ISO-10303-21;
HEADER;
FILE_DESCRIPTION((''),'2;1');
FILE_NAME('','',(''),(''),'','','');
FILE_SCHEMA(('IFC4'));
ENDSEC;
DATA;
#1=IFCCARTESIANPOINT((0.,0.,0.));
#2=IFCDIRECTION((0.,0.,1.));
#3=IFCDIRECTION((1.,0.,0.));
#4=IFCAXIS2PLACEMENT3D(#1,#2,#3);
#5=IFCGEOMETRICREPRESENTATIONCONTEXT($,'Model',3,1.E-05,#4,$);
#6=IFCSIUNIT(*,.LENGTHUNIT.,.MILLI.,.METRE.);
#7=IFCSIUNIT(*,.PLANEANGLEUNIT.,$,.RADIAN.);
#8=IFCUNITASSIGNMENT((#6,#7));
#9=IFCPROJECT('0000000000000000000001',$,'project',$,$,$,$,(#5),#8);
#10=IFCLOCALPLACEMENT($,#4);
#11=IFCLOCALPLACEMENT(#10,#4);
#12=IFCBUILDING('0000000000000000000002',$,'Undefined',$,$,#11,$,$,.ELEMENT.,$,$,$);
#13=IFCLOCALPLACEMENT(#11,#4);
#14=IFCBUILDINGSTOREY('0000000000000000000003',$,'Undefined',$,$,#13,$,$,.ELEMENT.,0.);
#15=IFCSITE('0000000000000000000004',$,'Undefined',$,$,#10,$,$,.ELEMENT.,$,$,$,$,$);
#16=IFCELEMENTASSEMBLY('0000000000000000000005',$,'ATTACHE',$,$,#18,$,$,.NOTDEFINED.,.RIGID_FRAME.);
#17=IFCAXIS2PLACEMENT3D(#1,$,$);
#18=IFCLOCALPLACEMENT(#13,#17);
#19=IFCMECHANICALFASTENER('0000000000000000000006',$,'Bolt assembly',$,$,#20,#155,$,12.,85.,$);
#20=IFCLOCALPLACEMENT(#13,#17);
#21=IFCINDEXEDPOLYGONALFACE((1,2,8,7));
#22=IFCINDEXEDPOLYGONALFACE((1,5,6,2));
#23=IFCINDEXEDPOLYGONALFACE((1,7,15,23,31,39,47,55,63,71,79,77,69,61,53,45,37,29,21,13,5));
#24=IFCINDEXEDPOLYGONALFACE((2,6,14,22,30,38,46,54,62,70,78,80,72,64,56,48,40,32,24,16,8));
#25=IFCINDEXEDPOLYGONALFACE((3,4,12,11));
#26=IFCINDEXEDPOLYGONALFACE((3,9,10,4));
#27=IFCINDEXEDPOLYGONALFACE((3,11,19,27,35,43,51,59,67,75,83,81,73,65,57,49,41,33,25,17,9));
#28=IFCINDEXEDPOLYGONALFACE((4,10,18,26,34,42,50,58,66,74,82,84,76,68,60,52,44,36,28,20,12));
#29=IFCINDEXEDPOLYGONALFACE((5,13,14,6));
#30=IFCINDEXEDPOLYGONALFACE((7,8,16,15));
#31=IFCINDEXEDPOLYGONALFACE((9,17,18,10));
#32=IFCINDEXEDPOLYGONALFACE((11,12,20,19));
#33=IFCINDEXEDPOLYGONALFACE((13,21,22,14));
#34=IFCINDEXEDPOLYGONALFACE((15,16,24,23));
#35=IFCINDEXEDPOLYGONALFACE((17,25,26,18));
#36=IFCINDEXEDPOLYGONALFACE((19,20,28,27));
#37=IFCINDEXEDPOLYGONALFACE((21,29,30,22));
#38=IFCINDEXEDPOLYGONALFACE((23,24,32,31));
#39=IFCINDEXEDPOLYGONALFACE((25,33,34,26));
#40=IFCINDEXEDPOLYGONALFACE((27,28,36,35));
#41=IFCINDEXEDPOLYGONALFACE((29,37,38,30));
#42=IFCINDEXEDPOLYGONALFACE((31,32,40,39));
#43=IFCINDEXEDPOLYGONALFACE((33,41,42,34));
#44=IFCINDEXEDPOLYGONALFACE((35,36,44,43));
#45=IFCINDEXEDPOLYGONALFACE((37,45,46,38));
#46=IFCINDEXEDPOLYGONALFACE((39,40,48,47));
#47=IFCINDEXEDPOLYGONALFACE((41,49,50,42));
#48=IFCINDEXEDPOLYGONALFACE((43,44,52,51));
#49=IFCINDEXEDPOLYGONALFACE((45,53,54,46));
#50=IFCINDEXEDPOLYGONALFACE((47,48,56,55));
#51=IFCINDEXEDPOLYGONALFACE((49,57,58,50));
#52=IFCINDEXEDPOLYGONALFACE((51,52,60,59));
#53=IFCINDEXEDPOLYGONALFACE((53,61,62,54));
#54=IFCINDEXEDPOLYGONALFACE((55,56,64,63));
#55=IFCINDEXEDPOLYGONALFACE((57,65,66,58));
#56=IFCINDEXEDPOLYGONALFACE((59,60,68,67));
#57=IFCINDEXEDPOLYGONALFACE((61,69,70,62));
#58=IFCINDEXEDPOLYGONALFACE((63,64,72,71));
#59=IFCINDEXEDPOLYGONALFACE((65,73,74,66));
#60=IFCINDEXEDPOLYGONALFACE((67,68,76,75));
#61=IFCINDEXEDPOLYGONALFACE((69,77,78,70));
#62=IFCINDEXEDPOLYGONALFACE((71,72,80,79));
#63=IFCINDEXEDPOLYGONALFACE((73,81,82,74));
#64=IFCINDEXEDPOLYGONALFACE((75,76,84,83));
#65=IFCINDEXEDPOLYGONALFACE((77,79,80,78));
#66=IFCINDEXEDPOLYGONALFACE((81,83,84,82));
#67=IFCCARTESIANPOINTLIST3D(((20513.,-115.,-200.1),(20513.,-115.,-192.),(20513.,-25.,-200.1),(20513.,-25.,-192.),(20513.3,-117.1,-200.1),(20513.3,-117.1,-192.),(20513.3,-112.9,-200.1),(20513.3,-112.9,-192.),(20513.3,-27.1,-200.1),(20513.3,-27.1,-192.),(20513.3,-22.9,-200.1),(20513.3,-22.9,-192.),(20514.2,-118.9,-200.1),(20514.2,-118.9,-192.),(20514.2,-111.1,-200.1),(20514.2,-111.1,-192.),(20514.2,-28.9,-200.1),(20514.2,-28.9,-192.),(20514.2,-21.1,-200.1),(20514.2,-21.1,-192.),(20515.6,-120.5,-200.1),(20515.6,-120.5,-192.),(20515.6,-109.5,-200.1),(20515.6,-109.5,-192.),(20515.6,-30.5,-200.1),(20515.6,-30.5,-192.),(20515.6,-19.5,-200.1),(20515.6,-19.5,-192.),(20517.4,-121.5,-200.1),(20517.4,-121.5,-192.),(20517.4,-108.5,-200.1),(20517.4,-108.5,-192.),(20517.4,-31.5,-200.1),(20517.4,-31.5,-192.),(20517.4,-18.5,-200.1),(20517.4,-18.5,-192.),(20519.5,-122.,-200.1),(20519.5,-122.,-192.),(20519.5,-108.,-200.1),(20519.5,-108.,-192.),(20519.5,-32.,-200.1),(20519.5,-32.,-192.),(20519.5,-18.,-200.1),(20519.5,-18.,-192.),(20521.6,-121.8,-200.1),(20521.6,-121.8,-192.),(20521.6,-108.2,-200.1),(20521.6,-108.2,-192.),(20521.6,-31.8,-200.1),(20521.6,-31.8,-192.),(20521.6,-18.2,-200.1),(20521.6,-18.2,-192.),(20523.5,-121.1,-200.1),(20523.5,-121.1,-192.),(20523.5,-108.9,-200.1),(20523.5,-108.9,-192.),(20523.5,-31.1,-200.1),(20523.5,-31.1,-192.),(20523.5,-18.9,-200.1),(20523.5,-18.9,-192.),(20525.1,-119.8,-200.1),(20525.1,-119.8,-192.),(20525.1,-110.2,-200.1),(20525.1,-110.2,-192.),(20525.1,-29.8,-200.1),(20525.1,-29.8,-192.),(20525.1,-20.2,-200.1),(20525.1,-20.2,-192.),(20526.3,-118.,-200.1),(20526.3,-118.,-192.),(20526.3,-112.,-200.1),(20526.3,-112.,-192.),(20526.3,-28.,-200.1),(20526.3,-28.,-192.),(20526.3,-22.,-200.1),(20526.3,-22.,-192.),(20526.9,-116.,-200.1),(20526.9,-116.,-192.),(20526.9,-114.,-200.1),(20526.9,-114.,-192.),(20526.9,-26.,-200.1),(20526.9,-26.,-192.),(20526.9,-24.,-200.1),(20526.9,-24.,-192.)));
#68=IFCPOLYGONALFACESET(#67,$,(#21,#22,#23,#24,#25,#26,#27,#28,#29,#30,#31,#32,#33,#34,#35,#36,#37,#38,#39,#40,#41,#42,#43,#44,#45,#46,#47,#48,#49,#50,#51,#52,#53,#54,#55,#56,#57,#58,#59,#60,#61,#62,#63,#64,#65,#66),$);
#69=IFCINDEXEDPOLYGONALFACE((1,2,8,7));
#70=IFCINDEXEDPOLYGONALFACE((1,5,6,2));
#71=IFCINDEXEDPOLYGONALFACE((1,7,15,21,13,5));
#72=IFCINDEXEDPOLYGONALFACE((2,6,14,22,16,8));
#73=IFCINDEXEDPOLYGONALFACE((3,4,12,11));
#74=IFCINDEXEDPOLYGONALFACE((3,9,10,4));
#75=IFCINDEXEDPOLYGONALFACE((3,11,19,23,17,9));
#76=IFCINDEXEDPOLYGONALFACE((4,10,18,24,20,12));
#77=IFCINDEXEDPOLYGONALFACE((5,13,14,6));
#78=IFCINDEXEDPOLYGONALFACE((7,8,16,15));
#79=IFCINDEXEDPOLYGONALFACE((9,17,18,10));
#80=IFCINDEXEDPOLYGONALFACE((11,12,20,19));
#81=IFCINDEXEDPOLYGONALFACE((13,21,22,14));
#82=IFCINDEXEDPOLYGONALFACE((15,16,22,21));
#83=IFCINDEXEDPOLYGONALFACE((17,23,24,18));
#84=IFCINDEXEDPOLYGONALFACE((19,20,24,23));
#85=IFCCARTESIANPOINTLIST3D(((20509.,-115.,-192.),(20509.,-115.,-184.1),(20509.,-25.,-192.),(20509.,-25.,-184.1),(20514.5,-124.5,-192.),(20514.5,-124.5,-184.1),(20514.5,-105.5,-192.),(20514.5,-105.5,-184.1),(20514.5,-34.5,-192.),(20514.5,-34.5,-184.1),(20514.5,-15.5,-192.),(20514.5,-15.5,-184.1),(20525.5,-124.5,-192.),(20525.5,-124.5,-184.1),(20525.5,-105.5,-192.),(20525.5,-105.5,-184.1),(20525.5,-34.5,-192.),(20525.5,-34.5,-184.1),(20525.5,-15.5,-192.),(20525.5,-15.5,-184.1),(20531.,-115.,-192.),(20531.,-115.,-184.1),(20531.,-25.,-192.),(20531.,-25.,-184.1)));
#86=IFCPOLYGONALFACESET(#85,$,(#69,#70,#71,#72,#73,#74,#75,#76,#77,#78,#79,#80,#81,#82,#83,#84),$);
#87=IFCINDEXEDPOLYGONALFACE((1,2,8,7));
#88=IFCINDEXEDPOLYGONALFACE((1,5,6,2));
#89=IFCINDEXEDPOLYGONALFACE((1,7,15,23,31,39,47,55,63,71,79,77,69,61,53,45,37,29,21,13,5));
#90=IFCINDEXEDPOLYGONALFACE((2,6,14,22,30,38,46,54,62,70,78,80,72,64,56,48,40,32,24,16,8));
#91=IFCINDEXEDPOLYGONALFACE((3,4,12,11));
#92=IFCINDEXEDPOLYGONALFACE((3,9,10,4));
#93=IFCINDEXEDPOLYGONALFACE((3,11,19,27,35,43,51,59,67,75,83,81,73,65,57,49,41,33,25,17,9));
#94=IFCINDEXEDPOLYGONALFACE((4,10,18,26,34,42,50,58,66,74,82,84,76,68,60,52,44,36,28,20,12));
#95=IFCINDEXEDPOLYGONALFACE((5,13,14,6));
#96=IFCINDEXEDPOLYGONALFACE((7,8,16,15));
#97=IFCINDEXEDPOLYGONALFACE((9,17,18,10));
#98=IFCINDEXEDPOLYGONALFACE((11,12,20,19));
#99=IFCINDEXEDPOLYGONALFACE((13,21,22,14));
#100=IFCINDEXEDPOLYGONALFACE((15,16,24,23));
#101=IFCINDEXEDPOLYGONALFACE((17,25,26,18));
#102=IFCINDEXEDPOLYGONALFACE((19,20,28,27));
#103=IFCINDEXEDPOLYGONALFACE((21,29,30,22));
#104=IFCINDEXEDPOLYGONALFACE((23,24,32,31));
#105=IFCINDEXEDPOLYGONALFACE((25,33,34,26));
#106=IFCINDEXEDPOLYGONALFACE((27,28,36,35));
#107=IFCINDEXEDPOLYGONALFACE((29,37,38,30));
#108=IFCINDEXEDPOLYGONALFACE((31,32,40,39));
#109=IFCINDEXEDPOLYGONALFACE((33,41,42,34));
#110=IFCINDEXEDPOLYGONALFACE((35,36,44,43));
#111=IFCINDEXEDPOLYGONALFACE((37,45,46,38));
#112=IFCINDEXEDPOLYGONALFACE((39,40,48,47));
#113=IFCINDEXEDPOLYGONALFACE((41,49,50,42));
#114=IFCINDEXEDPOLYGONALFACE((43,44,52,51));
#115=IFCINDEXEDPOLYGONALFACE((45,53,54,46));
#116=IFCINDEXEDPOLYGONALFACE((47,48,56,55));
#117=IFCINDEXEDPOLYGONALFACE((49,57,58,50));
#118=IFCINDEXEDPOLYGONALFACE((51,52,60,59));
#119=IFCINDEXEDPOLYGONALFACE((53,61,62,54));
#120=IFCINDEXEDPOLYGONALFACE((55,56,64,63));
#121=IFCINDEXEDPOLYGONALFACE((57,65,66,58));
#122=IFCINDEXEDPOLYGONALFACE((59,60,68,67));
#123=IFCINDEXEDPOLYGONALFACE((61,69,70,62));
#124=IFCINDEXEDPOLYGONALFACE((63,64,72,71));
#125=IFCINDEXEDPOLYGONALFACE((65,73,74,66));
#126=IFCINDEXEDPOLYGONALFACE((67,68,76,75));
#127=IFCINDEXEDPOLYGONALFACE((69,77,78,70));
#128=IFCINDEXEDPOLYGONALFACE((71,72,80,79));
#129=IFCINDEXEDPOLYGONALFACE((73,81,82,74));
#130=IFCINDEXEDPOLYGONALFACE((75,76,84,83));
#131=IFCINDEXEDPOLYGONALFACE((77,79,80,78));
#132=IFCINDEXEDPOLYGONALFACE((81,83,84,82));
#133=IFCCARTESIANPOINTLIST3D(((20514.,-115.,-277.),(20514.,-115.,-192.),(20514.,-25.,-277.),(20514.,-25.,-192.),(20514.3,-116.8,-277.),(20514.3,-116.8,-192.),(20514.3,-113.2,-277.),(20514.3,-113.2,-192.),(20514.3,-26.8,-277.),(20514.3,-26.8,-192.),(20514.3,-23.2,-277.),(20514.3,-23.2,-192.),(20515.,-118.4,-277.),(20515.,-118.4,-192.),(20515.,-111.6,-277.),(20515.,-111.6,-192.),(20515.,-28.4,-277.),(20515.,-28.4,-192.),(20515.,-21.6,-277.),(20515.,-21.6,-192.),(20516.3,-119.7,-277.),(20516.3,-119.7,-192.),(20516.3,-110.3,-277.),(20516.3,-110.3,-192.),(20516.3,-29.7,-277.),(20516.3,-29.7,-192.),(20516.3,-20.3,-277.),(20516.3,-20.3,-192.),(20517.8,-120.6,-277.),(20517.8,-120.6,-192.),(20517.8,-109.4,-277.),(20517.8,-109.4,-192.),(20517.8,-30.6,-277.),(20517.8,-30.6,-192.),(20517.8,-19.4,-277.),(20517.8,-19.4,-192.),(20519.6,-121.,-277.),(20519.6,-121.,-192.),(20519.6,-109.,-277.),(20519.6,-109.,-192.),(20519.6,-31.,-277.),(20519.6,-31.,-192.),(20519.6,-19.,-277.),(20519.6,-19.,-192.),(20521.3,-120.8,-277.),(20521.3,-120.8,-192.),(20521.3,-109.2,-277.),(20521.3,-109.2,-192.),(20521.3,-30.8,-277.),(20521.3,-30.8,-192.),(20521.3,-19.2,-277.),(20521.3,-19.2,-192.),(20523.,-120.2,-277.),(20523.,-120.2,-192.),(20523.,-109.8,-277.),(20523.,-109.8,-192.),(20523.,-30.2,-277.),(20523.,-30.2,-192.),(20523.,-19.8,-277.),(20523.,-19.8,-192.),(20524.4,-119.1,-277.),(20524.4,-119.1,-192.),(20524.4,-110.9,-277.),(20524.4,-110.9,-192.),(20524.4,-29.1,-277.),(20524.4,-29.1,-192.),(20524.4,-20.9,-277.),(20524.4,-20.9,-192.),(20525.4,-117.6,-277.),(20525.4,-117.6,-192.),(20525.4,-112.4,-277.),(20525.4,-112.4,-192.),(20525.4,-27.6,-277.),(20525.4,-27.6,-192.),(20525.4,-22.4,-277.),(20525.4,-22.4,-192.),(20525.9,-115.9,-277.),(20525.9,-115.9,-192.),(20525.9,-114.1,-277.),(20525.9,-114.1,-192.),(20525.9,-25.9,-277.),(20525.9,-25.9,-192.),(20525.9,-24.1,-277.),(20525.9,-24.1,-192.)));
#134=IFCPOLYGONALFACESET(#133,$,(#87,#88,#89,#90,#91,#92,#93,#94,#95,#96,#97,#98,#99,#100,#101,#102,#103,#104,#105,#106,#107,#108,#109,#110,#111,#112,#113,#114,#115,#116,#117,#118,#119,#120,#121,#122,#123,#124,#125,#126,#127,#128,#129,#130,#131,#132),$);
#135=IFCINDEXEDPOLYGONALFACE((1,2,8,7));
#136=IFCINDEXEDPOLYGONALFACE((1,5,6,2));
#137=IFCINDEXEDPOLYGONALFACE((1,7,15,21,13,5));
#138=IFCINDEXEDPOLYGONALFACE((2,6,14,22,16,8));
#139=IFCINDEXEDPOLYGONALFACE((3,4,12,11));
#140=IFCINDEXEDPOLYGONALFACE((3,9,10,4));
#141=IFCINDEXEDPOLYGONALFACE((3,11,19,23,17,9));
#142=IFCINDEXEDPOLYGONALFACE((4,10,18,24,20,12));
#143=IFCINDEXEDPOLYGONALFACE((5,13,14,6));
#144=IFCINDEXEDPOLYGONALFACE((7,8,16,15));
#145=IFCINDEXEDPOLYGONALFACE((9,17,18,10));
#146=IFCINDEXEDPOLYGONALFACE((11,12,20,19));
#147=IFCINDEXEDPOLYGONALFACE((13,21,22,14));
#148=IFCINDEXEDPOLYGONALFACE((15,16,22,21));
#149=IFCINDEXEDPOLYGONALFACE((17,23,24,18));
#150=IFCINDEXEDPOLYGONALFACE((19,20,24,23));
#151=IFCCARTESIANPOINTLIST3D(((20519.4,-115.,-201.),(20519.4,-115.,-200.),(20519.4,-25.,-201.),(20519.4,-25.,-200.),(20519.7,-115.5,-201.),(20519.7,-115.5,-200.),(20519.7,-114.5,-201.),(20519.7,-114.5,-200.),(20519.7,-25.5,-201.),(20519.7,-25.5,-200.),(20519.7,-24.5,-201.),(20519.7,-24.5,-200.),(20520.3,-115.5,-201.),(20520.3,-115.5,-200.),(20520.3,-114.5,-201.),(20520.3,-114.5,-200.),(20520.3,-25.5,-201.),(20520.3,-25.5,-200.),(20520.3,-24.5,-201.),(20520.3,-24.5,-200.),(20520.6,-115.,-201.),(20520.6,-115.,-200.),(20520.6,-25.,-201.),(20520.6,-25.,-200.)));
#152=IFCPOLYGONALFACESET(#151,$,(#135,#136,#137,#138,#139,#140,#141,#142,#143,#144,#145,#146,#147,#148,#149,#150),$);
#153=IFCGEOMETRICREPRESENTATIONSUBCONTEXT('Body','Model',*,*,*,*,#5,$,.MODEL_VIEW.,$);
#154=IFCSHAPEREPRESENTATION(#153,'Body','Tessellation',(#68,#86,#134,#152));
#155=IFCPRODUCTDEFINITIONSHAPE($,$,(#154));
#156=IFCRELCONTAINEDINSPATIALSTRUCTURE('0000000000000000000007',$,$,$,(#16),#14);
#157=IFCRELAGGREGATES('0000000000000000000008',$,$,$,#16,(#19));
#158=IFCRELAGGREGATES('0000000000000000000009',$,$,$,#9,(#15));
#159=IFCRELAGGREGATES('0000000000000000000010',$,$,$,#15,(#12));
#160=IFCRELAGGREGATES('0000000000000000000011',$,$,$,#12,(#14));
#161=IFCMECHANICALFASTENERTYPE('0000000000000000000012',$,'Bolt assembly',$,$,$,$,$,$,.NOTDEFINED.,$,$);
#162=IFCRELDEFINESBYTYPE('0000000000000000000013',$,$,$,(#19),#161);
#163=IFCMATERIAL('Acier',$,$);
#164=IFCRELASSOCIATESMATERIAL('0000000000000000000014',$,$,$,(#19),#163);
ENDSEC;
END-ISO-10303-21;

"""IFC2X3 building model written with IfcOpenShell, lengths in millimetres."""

from ifc_helpers import new_model, si_unit, frame, origin_with_axes, origin_2d_with_axis, place, context, subcontext, project, spatial, polyline, circle, outline, extrude, source, transform, mapped, material, type_object, element, aggregate, save


model = new_model("IFC2X3")

# Units and contexts
model_context = context("Model", 3, precision=1e-05, world=origin_with_axes())
body_context = subcontext(model_context, "Body", "Model", "MODEL_VIEW")
ifc_project = project(units=[si_unit("LENGTHUNIT", "METRE", prefix="MILLI"), si_unit("PLANEANGLEUNIT", "RADIAN")], contexts=[model_context])

# Site, building, storey
site_placement = place(None, origin_with_axes())
site = spatial("IfcSite", under=ifc_project, at=site_placement, Name="Undefined", CompositionType="ELEMENT")
building_placement = place(site_placement, origin_with_axes())
building = spatial("IfcBuilding", under=site, at=building_placement, Name="Undefined", CompositionType="ELEMENT")
storey_placement = place(building_placement, origin_with_axes())
storey = spatial("IfcBuildingStorey", under=building, at=storey_placement, Name="Undefined", CompositionType="ELEMENT", Elevation=0.0)

# Element assembly
assembly_1_placement = place(storey_placement, origin_with_axes())
assembly_1 = element("IfcElementAssembly", 1, at=assembly_1_placement, inside=storey, Name="ATTACHE", AssemblyPlace="NOTDEFINED", PredefinedType="RIGID_FRAME")

# Mechanical fastener
mechanical_fastener_type = type_object("IfcMechanicalFastenerType", Name="Bolt assembly")
ifc_material_1 = material(Name="Acier")
shared_shape_1 = source(origin_with_axes(), body_context, "Body", "SweptSolid", [
    extrude(circle(Radius=7.0, at=origin_2d_with_axis()), frame((0.0, -8.0, 0.0), z_axis=(0.0, 1.0, 0.0), x_axis=(1.0, 0.0, 0.0)), (0.0, 0.0, 1.0), 8.1),
    extrude(outline(polyline([(11.0, 0.0), (5.5, 9.5), (-5.5, 9.5), (-11.0, 0.0), (-5.5, -9.5), (5.5, -9.5), (11.0, 0.0)])), frame((0.0, -15.9, 0.0), z_axis=(0.0, 1.0, 0.0), x_axis=(1.0, 0.0, 0.0)), (0.0, 0.0, 1.0), 7.9),
    extrude(circle(Radius=6.0, at=origin_2d_with_axis()), frame((0.0, -8.0, 0.0), z_axis=(0.0, 1.0, 0.0), x_axis=(1.0, 0.0, 0.0)), (0.0, 0.0, 1.0), 85.0),
    extrude(outline(polyline([(0.6, 0.0), (0.3, 0.5), (-0.3, 0.5), (-0.6, 0.0), (-0.3, -0.5), (0.3, -0.5), (0.6, 0.0)])), frame((0.0, 0.0, 0.0), z_axis=(0.0, 1.0, 0.0), x_axis=(1.0, 0.0, 0.0)), (0.0, 0.0, 1.0), 1.0),
])
mechanical_fastener_1_placement = place(assembly_1_placement, frame((20520.0, -70.0, -200.0), z_axis=(0.0, -1.0, 0.0), x_axis=(-1.0, 0.0, 0.0)))
mechanical_fastener_1 = element("IfcMechanicalFastener", 2, at=mechanical_fastener_1_placement, type_object=mechanical_fastener_type, material=ifc_material_1, Name="Bolt assembly", NominalDiameter=12.0, NominalLength=85.0, context=body_context, shape_type="MappedRepresentation", body=[
    mapped(shared_shape_1, transform((0.0, 0.0, -45.0))),
    mapped(shared_shape_1, transform((0.0, 0.0, 45.0))),
])
aggregate(assembly_1, [mechanical_fastener_1])

save(model, "model.ifc")
